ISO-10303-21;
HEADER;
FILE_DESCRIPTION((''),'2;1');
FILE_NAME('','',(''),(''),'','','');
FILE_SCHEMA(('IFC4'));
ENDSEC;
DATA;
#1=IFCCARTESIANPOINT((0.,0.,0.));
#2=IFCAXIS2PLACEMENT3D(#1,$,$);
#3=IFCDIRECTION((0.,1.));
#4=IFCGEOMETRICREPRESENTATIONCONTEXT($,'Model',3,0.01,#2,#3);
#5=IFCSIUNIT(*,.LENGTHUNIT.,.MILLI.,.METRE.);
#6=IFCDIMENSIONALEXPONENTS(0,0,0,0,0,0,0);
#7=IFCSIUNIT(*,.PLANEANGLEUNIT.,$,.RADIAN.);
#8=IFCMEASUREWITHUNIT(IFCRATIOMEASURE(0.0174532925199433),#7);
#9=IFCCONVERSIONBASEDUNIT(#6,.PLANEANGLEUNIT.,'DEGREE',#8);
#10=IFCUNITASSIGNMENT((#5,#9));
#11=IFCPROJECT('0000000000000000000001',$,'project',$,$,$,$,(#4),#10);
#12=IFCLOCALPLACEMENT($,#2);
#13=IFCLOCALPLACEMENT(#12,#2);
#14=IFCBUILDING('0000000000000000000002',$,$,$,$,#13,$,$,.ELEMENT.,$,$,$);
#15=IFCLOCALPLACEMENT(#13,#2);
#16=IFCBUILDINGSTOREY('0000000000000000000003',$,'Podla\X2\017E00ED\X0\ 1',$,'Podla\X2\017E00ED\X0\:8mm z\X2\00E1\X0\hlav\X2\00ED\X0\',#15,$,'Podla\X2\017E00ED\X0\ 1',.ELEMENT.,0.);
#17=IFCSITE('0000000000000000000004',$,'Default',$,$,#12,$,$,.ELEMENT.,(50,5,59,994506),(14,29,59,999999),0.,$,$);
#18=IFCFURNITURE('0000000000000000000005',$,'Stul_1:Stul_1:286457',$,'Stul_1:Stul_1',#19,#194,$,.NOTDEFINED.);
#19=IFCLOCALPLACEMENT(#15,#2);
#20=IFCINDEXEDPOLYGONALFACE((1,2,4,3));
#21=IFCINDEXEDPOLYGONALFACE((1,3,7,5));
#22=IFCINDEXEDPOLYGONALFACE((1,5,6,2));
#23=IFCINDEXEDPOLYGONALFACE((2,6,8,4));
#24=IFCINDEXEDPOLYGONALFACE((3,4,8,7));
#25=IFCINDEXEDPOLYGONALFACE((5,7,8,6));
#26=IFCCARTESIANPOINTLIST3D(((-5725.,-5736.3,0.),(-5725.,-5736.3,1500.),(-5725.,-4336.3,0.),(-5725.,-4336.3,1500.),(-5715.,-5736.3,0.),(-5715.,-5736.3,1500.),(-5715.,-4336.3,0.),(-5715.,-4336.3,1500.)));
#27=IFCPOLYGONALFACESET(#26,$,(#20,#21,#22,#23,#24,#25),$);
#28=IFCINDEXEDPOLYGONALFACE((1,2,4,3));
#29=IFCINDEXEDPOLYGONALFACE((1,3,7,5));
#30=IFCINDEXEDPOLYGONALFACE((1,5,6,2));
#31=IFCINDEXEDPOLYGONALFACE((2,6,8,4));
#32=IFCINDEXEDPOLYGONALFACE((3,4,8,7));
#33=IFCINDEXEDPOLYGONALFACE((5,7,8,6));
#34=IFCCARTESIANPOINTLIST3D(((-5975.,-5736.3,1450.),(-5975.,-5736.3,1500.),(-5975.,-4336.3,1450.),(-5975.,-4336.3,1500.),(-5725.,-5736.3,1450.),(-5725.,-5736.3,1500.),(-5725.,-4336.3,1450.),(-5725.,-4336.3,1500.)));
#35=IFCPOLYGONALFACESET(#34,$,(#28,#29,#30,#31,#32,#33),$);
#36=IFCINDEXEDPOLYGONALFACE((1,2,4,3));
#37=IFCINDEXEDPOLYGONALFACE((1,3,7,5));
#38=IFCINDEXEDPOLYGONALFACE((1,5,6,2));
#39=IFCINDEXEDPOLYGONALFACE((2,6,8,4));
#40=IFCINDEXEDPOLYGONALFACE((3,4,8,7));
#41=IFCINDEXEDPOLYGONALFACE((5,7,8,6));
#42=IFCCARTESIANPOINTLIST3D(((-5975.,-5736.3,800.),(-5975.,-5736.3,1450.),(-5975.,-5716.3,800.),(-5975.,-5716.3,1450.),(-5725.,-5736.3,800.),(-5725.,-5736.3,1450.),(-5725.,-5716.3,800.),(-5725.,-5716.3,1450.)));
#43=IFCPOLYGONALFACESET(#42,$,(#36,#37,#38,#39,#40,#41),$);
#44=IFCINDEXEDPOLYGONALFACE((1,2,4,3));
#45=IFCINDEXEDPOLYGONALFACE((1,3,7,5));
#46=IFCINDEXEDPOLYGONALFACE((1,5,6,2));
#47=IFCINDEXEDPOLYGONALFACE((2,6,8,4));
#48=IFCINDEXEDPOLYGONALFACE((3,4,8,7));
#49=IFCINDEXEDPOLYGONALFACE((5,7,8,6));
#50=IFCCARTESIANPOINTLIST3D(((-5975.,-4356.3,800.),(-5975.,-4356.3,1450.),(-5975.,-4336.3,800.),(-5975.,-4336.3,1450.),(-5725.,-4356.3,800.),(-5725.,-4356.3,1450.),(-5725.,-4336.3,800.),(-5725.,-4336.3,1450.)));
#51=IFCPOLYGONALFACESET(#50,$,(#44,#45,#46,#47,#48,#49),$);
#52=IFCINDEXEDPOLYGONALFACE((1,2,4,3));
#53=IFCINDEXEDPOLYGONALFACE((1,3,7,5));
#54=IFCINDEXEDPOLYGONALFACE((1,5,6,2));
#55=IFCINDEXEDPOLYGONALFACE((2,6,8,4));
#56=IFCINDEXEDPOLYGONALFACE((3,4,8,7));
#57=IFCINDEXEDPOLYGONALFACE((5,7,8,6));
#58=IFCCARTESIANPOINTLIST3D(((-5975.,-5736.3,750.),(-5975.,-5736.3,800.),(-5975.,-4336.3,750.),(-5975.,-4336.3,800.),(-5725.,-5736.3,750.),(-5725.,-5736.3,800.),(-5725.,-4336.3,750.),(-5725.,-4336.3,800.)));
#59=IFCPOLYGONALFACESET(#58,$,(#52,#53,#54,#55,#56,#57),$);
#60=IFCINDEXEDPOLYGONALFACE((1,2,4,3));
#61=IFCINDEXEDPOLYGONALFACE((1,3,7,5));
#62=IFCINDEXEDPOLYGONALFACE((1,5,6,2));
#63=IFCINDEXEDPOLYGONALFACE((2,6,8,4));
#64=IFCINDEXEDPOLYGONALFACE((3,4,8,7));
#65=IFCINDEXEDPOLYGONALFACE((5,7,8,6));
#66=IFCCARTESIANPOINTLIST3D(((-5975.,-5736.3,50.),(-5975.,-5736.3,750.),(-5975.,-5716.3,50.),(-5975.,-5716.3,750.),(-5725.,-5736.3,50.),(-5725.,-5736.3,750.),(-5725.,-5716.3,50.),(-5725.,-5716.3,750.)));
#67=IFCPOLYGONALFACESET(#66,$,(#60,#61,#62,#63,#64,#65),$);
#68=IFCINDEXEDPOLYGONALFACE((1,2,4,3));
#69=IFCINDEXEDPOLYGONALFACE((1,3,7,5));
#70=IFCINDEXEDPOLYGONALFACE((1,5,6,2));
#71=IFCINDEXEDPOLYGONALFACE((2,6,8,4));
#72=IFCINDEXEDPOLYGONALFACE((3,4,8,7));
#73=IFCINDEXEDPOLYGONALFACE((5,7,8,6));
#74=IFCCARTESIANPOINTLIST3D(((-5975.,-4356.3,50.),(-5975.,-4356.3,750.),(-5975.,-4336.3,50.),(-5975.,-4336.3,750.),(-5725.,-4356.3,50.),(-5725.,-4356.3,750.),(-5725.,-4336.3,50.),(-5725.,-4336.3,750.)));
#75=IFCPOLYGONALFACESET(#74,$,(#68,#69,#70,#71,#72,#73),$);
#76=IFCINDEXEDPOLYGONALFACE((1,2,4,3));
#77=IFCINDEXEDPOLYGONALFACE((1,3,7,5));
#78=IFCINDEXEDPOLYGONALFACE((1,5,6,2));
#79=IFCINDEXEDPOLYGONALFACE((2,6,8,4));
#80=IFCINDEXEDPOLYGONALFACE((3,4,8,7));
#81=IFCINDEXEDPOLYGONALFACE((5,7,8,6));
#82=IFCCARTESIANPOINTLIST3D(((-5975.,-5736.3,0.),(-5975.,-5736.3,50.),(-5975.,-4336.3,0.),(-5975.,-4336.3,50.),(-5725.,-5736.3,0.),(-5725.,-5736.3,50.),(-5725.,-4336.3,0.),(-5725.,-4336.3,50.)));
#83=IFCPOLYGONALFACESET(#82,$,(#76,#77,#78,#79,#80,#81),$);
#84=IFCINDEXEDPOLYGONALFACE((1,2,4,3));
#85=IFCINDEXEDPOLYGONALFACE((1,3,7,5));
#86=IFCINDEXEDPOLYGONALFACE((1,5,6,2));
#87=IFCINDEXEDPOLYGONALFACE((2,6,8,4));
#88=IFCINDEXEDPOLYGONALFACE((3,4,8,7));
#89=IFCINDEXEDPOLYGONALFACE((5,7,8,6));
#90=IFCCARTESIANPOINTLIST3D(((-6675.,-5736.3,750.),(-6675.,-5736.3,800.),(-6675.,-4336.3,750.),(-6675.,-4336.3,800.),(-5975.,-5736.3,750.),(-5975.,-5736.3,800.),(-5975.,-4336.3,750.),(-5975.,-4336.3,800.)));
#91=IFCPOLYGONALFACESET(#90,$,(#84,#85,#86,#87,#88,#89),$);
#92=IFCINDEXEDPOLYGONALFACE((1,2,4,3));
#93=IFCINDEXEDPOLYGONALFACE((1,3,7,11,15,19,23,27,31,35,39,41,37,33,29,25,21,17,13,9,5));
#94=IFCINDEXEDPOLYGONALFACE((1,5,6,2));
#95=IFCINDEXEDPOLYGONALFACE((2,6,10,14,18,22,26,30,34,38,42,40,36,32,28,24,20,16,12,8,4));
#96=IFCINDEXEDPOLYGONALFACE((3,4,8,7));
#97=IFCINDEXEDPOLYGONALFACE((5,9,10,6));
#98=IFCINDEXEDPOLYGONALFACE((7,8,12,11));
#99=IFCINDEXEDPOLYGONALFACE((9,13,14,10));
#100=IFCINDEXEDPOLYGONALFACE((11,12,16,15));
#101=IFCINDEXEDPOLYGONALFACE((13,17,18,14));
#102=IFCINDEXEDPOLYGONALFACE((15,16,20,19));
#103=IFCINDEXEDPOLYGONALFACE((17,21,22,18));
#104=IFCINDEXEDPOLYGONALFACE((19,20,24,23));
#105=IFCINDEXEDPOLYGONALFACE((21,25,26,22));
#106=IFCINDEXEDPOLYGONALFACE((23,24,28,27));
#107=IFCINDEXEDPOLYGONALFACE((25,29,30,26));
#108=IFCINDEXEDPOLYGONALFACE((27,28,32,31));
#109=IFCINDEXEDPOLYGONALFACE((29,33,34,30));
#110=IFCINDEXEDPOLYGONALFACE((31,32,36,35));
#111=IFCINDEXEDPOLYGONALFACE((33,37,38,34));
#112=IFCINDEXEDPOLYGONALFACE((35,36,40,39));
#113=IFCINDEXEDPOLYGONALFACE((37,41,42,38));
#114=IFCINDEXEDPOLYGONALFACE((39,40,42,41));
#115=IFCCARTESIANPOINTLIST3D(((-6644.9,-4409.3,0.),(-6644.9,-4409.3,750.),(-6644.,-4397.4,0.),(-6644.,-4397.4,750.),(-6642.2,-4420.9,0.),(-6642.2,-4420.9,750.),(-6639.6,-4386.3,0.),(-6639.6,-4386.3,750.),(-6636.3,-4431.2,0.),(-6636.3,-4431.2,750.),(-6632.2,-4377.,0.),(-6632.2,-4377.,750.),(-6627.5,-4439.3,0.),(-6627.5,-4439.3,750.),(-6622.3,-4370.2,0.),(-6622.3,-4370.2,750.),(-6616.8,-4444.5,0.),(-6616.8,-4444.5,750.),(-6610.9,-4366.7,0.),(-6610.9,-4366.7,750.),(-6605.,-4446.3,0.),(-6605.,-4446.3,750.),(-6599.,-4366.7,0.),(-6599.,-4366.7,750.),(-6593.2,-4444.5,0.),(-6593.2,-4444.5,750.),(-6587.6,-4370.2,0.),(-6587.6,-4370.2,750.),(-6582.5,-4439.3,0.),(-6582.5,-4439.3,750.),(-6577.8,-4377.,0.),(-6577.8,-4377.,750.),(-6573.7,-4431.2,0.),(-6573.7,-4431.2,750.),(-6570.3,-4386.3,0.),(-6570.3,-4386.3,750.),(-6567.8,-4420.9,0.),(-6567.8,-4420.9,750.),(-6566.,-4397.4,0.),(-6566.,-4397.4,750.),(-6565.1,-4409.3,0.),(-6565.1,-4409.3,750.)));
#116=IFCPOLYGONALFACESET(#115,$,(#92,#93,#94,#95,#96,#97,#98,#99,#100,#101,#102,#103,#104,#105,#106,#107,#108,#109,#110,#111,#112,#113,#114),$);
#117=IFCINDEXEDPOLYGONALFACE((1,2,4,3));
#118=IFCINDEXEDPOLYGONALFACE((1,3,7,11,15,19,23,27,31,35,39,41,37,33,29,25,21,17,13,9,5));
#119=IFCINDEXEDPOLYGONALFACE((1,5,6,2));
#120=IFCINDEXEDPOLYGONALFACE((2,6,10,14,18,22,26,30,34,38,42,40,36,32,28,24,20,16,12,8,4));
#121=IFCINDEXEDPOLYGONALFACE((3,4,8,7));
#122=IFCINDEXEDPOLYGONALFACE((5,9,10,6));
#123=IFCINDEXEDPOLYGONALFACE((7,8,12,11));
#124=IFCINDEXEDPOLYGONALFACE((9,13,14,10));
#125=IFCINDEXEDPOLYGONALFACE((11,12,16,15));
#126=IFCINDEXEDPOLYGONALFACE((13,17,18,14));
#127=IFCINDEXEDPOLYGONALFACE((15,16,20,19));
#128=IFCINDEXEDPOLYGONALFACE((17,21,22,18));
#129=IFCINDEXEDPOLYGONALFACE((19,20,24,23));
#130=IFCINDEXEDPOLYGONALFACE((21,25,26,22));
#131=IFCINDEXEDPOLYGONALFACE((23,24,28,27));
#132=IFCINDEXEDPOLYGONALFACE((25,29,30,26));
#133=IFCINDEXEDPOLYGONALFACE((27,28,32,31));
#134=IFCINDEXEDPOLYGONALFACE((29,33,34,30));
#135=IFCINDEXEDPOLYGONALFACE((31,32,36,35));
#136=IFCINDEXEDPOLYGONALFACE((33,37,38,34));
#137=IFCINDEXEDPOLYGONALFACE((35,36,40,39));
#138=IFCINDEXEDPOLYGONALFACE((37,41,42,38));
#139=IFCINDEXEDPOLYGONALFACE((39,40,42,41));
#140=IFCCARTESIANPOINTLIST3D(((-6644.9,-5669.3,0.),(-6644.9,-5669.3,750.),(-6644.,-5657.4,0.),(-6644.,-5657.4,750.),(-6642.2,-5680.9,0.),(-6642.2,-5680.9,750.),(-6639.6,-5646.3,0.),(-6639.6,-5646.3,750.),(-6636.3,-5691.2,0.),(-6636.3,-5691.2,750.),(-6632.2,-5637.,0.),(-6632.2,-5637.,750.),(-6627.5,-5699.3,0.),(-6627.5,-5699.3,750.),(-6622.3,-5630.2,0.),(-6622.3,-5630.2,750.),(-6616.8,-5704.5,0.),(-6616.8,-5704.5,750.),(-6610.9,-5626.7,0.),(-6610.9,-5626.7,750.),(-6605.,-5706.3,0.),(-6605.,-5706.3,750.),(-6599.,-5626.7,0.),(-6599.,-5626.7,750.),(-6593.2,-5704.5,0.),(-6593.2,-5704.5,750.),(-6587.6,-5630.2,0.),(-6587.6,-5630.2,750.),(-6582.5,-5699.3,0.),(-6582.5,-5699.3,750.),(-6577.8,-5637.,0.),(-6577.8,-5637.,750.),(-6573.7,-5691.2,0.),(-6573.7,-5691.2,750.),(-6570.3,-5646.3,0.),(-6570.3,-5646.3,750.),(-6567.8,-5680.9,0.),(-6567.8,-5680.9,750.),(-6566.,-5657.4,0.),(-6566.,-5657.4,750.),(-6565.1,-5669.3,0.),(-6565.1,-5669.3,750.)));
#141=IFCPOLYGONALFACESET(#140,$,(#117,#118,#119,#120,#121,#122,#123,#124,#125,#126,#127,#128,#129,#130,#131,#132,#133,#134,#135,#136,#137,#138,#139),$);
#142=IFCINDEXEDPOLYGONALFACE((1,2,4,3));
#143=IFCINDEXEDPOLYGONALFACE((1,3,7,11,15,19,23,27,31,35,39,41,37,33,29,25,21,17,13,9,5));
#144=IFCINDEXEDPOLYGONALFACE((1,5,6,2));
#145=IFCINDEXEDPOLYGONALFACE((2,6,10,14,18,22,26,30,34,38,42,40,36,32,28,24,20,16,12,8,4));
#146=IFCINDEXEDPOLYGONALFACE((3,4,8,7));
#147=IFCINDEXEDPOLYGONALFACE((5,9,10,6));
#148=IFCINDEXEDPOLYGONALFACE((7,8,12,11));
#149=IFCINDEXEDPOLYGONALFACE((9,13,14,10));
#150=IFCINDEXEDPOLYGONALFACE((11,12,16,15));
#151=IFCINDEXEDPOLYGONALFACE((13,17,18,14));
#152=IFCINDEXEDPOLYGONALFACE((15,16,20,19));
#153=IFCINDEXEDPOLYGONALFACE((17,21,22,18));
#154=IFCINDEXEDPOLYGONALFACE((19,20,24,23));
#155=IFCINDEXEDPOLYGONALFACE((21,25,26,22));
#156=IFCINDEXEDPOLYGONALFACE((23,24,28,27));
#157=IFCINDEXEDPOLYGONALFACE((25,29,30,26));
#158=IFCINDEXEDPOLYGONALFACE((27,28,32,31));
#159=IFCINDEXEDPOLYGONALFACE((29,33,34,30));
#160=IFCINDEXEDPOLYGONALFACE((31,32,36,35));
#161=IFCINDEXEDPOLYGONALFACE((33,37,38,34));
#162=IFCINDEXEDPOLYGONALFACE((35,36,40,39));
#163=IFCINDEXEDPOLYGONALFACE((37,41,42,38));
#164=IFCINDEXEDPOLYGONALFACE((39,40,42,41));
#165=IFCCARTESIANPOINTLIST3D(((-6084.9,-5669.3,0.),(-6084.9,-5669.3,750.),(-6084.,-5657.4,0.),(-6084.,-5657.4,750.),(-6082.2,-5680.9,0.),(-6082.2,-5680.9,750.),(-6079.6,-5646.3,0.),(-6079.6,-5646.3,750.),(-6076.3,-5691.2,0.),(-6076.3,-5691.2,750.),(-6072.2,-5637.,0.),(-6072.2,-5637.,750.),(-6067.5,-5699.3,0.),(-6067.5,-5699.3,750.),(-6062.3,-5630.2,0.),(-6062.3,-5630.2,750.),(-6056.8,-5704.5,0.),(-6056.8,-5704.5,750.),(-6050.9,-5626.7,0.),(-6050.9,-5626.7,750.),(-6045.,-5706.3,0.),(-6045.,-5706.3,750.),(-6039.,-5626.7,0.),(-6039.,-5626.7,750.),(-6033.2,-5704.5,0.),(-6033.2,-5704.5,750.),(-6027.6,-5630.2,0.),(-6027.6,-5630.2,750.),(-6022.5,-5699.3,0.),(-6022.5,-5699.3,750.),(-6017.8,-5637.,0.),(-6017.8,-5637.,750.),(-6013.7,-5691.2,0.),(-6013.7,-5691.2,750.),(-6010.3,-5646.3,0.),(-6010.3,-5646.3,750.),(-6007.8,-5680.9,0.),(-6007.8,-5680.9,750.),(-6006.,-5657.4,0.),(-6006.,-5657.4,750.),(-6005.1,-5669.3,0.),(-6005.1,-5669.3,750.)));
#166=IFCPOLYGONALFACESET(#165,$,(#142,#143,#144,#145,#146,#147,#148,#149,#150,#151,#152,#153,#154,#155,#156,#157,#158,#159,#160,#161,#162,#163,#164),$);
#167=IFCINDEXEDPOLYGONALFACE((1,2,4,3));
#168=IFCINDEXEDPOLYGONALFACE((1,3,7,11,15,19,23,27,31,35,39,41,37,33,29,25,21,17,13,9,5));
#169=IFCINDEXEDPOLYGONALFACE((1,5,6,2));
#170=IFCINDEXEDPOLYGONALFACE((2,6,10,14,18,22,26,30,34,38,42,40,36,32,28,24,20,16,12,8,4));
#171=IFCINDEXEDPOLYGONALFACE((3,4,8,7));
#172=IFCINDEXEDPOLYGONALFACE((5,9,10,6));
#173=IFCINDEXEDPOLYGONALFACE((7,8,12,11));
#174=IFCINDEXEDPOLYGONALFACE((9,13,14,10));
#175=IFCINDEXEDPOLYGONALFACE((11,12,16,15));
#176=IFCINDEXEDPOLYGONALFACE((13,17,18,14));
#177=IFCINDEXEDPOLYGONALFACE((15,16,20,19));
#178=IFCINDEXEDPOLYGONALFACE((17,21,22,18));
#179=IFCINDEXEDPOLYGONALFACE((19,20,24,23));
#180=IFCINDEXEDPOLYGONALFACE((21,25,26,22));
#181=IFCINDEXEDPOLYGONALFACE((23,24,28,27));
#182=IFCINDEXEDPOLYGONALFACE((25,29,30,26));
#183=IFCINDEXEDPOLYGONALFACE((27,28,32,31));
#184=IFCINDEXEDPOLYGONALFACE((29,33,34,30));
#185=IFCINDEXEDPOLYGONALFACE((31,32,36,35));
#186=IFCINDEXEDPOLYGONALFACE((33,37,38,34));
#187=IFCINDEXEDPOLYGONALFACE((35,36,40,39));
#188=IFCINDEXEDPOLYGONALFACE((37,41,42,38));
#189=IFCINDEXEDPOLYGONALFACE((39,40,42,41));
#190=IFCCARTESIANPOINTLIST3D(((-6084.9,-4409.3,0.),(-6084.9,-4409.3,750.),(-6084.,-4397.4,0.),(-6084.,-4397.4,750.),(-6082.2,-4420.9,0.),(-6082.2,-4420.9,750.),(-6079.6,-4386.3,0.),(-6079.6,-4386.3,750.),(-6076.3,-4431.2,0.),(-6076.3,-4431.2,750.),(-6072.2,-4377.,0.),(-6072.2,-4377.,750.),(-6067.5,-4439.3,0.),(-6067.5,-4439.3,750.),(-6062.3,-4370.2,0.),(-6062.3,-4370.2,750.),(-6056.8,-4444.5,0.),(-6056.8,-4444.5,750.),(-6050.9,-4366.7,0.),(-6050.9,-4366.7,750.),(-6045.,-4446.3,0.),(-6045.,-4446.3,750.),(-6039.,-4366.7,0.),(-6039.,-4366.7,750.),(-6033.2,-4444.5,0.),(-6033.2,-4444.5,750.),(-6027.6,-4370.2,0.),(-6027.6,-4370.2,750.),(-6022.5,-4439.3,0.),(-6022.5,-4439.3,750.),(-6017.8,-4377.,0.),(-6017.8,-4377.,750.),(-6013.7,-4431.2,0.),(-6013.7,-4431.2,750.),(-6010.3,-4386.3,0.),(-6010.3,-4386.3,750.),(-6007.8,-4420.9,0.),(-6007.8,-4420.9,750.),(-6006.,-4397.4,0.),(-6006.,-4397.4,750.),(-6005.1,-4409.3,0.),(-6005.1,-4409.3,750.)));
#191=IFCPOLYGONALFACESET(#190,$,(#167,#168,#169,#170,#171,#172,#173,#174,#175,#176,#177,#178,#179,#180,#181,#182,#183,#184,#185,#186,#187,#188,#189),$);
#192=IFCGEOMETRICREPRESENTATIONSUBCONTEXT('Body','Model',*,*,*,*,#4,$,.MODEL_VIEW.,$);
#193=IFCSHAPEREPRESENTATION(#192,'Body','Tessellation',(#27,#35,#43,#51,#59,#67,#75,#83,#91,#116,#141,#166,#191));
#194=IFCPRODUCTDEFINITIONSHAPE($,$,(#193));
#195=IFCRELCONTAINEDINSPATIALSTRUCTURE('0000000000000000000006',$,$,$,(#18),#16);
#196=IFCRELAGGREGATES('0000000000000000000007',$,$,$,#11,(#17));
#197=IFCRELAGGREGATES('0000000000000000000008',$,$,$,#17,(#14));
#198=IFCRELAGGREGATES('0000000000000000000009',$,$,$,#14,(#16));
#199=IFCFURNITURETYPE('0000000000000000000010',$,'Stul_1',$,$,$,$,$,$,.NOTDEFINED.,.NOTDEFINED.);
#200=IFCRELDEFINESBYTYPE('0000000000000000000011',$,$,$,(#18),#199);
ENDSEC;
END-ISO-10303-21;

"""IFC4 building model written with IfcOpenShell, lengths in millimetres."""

from ifc_helpers import new_model, entity, si_unit, converted_unit, direction, frame, frame_2d, origin, origin_2d_with_axis, place, context, subcontext, project, spatial, rectangle, circle, extrude, source, transform, mapped, type_object, type_shapes, element, save


model = new_model("IFC4")

# Units and contexts
model_context = context("Model", 3, precision=0.01, world=origin(), true_north=direction((0.0, 1.0)))
body_context = subcontext(model_context, "Body", "Model", "MODEL_VIEW")
ifc_project = project(units=[si_unit("LENGTHUNIT", "METRE", prefix="MILLI"), converted_unit("PLANEANGLEUNIT", "DEGREE", entity("IfcRatioMeasure", 0.0174532925199433), si_unit("PLANEANGLEUNIT", "RADIAN"), dimensions=[0, 0, 0, 0, 0, 0, 0])], contexts=[model_context])

# Site, building, storey
site_placement = place(None, origin())
site = spatial("IfcSite", under=ifc_project, at=site_placement, Name="Default", CompositionType="ELEMENT", RefLatitude=(50, 5, 59, 994506), RefLongitude=(14, 29, 59, 999999), RefElevation=0.0)
building_placement = place(site_placement, origin())
building = spatial("IfcBuilding", under=site, at=building_placement, CompositionType="ELEMENT")
storey_placement = place(building_placement, origin())
storey = spatial("IfcBuildingStorey", under=building, at=storey_placement, Name="Podlaží 1", ObjectType="Podlaží:8mm záhlaví", LongName="Podlaží 1", CompositionType="ELEMENT", Elevation=0.0)

# Furniture
furniture_type = type_object("IfcFurnitureType", Name="Stul_1", AssemblyPlace="NOTDEFINED", PredefinedType="NOTDEFINED")
shared_shape_1 = source(origin(), body_context, "Body", "SweptSolid", [
    extrude(rectangle(XDim=1400.0, YDim=10.0, at=origin_2d_with_axis()), frame((0.0, 605.0, 0.0), z_axis=(0.0, 0.0, 1.0), x_axis=(-1.0, 0.0, 0.0)), (0.0, 0.0, 1.0), 1500.0),
    extrude(rectangle(XDim=1400.0, YDim=250.0, at=frame_2d((0.0, 0.0), x_axis=(1.0, 0.0))), frame((0.0, 475.0, 1450.0), z_axis=(0.0, 0.0, 1.0), x_axis=(-1.0, 0.0, 0.0)), (0.0, 0.0, 1.0), 50.0),
    extrude(rectangle(XDim=20.0, YDim=250.0, at=origin_2d_with_axis()), frame((690.0, 475.0, 800.0), z_axis=(0.0, 0.0, 1.0), x_axis=(-1.0, 0.0, 0.0)), (0.0, 0.0, 1.0), 650.0),
    extrude(rectangle(XDim=20.0, YDim=250.0, at=frame_2d((0.0, 0.0), x_axis=(1.0, 0.0))), frame((-690.0, 475.0, 800.0), z_axis=(0.0, 0.0, 1.0), x_axis=(-1.0, 0.0, 0.0)), (0.0, 0.0, 1.0), 650.0),
    extrude(rectangle(XDim=1400.0, YDim=250.0, at=origin_2d_with_axis()), frame((0.0, 475.0, 750.0), z_axis=(0.0, 0.0, 1.0), x_axis=(-1.0, 0.0, 0.0)), (0.0, 0.0, 1.0), 50.0),
    extrude(rectangle(XDim=20.0, YDim=250.0, at=origin_2d_with_axis()), frame((690.0, 475.0, 50.0), z_axis=(0.0, 0.0, 1.0), x_axis=(-1.0, 0.0, 0.0)), (0.0, 0.0, 1.0), 700.0),
    extrude(rectangle(XDim=20.0, YDim=250.0, at=frame_2d((0.0, 0.0), x_axis=(1.0, 0.0))), frame((-690.0, 475.0, 50.0), z_axis=(0.0, 0.0, 1.0), x_axis=(-1.0, 0.0, 0.0)), (0.0, 0.0, 1.0), 700.0),
    extrude(rectangle(XDim=1400.0, YDim=250.0, at=origin_2d_with_axis()), frame((0.0, 475.0, 0.0), z_axis=(0.0, 0.0, 1.0), x_axis=(-1.0, 0.0, 0.0)), (0.0, 0.0, 1.0), 50.0),
    extrude(rectangle(XDim=1400.0, YDim=700.0, at=origin_2d_with_axis()), frame((0.0, 0.0, 750.0), z_axis=(0.0, 0.0, 1.0), x_axis=(-1.0, 0.0, 0.0)), (0.0, 0.0, 1.0), 50.0),
    extrude(circle(Radius=40.0, at=frame_2d((0.0, 0.0), x_axis=(1.0, 0.0))), frame((-630.0, -280.0, 0.0)), (0.0, 0.0, 1.0), 750.0),
    extrude(circle(Radius=40.0, at=frame_2d((0.0, 0.0), x_axis=(1.0, 0.0))), frame((630.0, -280.0, 0.0)), (0.0, 0.0, 1.0), 750.0),
    extrude(circle(Radius=40.0, at=frame_2d((0.0, 0.0), x_axis=(1.0, 0.0))), frame((630.0, 280.0, 0.0)), (0.0, 0.0, 1.0), 750.0),
    extrude(circle(Radius=40.0, at=frame_2d((0.0, 0.0), x_axis=(1.0, 0.0))), frame((-630.0, 280.0, 0.0)), (0.0, 0.0, 1.0), 750.0),
])
type_shapes(furniture_type, [shared_shape_1])
for number, where, z_axis, x_axis, name in (
    (1, (-6325.0, -5036.3, 0.0), (0.0, 0.0, 1.0), (0.0, -1.0, 0.0), "Stul_1:Stul_1:286457"),
):
    element("IfcFurniture", number, at=place(storey_placement, frame(where, z_axis=z_axis, x_axis=x_axis)), inside=storey, type_object=furniture_type, Name=name, ObjectType="Stul_1:Stul_1", PredefinedType="NOTDEFINED", context=body_context, shape_type="MappedRepresentation", body=[
        mapped(shared_shape_1, transform((0.0, 0.0, 0.0), scale=1.0)),
    ])

save(model, "model.ifc")
